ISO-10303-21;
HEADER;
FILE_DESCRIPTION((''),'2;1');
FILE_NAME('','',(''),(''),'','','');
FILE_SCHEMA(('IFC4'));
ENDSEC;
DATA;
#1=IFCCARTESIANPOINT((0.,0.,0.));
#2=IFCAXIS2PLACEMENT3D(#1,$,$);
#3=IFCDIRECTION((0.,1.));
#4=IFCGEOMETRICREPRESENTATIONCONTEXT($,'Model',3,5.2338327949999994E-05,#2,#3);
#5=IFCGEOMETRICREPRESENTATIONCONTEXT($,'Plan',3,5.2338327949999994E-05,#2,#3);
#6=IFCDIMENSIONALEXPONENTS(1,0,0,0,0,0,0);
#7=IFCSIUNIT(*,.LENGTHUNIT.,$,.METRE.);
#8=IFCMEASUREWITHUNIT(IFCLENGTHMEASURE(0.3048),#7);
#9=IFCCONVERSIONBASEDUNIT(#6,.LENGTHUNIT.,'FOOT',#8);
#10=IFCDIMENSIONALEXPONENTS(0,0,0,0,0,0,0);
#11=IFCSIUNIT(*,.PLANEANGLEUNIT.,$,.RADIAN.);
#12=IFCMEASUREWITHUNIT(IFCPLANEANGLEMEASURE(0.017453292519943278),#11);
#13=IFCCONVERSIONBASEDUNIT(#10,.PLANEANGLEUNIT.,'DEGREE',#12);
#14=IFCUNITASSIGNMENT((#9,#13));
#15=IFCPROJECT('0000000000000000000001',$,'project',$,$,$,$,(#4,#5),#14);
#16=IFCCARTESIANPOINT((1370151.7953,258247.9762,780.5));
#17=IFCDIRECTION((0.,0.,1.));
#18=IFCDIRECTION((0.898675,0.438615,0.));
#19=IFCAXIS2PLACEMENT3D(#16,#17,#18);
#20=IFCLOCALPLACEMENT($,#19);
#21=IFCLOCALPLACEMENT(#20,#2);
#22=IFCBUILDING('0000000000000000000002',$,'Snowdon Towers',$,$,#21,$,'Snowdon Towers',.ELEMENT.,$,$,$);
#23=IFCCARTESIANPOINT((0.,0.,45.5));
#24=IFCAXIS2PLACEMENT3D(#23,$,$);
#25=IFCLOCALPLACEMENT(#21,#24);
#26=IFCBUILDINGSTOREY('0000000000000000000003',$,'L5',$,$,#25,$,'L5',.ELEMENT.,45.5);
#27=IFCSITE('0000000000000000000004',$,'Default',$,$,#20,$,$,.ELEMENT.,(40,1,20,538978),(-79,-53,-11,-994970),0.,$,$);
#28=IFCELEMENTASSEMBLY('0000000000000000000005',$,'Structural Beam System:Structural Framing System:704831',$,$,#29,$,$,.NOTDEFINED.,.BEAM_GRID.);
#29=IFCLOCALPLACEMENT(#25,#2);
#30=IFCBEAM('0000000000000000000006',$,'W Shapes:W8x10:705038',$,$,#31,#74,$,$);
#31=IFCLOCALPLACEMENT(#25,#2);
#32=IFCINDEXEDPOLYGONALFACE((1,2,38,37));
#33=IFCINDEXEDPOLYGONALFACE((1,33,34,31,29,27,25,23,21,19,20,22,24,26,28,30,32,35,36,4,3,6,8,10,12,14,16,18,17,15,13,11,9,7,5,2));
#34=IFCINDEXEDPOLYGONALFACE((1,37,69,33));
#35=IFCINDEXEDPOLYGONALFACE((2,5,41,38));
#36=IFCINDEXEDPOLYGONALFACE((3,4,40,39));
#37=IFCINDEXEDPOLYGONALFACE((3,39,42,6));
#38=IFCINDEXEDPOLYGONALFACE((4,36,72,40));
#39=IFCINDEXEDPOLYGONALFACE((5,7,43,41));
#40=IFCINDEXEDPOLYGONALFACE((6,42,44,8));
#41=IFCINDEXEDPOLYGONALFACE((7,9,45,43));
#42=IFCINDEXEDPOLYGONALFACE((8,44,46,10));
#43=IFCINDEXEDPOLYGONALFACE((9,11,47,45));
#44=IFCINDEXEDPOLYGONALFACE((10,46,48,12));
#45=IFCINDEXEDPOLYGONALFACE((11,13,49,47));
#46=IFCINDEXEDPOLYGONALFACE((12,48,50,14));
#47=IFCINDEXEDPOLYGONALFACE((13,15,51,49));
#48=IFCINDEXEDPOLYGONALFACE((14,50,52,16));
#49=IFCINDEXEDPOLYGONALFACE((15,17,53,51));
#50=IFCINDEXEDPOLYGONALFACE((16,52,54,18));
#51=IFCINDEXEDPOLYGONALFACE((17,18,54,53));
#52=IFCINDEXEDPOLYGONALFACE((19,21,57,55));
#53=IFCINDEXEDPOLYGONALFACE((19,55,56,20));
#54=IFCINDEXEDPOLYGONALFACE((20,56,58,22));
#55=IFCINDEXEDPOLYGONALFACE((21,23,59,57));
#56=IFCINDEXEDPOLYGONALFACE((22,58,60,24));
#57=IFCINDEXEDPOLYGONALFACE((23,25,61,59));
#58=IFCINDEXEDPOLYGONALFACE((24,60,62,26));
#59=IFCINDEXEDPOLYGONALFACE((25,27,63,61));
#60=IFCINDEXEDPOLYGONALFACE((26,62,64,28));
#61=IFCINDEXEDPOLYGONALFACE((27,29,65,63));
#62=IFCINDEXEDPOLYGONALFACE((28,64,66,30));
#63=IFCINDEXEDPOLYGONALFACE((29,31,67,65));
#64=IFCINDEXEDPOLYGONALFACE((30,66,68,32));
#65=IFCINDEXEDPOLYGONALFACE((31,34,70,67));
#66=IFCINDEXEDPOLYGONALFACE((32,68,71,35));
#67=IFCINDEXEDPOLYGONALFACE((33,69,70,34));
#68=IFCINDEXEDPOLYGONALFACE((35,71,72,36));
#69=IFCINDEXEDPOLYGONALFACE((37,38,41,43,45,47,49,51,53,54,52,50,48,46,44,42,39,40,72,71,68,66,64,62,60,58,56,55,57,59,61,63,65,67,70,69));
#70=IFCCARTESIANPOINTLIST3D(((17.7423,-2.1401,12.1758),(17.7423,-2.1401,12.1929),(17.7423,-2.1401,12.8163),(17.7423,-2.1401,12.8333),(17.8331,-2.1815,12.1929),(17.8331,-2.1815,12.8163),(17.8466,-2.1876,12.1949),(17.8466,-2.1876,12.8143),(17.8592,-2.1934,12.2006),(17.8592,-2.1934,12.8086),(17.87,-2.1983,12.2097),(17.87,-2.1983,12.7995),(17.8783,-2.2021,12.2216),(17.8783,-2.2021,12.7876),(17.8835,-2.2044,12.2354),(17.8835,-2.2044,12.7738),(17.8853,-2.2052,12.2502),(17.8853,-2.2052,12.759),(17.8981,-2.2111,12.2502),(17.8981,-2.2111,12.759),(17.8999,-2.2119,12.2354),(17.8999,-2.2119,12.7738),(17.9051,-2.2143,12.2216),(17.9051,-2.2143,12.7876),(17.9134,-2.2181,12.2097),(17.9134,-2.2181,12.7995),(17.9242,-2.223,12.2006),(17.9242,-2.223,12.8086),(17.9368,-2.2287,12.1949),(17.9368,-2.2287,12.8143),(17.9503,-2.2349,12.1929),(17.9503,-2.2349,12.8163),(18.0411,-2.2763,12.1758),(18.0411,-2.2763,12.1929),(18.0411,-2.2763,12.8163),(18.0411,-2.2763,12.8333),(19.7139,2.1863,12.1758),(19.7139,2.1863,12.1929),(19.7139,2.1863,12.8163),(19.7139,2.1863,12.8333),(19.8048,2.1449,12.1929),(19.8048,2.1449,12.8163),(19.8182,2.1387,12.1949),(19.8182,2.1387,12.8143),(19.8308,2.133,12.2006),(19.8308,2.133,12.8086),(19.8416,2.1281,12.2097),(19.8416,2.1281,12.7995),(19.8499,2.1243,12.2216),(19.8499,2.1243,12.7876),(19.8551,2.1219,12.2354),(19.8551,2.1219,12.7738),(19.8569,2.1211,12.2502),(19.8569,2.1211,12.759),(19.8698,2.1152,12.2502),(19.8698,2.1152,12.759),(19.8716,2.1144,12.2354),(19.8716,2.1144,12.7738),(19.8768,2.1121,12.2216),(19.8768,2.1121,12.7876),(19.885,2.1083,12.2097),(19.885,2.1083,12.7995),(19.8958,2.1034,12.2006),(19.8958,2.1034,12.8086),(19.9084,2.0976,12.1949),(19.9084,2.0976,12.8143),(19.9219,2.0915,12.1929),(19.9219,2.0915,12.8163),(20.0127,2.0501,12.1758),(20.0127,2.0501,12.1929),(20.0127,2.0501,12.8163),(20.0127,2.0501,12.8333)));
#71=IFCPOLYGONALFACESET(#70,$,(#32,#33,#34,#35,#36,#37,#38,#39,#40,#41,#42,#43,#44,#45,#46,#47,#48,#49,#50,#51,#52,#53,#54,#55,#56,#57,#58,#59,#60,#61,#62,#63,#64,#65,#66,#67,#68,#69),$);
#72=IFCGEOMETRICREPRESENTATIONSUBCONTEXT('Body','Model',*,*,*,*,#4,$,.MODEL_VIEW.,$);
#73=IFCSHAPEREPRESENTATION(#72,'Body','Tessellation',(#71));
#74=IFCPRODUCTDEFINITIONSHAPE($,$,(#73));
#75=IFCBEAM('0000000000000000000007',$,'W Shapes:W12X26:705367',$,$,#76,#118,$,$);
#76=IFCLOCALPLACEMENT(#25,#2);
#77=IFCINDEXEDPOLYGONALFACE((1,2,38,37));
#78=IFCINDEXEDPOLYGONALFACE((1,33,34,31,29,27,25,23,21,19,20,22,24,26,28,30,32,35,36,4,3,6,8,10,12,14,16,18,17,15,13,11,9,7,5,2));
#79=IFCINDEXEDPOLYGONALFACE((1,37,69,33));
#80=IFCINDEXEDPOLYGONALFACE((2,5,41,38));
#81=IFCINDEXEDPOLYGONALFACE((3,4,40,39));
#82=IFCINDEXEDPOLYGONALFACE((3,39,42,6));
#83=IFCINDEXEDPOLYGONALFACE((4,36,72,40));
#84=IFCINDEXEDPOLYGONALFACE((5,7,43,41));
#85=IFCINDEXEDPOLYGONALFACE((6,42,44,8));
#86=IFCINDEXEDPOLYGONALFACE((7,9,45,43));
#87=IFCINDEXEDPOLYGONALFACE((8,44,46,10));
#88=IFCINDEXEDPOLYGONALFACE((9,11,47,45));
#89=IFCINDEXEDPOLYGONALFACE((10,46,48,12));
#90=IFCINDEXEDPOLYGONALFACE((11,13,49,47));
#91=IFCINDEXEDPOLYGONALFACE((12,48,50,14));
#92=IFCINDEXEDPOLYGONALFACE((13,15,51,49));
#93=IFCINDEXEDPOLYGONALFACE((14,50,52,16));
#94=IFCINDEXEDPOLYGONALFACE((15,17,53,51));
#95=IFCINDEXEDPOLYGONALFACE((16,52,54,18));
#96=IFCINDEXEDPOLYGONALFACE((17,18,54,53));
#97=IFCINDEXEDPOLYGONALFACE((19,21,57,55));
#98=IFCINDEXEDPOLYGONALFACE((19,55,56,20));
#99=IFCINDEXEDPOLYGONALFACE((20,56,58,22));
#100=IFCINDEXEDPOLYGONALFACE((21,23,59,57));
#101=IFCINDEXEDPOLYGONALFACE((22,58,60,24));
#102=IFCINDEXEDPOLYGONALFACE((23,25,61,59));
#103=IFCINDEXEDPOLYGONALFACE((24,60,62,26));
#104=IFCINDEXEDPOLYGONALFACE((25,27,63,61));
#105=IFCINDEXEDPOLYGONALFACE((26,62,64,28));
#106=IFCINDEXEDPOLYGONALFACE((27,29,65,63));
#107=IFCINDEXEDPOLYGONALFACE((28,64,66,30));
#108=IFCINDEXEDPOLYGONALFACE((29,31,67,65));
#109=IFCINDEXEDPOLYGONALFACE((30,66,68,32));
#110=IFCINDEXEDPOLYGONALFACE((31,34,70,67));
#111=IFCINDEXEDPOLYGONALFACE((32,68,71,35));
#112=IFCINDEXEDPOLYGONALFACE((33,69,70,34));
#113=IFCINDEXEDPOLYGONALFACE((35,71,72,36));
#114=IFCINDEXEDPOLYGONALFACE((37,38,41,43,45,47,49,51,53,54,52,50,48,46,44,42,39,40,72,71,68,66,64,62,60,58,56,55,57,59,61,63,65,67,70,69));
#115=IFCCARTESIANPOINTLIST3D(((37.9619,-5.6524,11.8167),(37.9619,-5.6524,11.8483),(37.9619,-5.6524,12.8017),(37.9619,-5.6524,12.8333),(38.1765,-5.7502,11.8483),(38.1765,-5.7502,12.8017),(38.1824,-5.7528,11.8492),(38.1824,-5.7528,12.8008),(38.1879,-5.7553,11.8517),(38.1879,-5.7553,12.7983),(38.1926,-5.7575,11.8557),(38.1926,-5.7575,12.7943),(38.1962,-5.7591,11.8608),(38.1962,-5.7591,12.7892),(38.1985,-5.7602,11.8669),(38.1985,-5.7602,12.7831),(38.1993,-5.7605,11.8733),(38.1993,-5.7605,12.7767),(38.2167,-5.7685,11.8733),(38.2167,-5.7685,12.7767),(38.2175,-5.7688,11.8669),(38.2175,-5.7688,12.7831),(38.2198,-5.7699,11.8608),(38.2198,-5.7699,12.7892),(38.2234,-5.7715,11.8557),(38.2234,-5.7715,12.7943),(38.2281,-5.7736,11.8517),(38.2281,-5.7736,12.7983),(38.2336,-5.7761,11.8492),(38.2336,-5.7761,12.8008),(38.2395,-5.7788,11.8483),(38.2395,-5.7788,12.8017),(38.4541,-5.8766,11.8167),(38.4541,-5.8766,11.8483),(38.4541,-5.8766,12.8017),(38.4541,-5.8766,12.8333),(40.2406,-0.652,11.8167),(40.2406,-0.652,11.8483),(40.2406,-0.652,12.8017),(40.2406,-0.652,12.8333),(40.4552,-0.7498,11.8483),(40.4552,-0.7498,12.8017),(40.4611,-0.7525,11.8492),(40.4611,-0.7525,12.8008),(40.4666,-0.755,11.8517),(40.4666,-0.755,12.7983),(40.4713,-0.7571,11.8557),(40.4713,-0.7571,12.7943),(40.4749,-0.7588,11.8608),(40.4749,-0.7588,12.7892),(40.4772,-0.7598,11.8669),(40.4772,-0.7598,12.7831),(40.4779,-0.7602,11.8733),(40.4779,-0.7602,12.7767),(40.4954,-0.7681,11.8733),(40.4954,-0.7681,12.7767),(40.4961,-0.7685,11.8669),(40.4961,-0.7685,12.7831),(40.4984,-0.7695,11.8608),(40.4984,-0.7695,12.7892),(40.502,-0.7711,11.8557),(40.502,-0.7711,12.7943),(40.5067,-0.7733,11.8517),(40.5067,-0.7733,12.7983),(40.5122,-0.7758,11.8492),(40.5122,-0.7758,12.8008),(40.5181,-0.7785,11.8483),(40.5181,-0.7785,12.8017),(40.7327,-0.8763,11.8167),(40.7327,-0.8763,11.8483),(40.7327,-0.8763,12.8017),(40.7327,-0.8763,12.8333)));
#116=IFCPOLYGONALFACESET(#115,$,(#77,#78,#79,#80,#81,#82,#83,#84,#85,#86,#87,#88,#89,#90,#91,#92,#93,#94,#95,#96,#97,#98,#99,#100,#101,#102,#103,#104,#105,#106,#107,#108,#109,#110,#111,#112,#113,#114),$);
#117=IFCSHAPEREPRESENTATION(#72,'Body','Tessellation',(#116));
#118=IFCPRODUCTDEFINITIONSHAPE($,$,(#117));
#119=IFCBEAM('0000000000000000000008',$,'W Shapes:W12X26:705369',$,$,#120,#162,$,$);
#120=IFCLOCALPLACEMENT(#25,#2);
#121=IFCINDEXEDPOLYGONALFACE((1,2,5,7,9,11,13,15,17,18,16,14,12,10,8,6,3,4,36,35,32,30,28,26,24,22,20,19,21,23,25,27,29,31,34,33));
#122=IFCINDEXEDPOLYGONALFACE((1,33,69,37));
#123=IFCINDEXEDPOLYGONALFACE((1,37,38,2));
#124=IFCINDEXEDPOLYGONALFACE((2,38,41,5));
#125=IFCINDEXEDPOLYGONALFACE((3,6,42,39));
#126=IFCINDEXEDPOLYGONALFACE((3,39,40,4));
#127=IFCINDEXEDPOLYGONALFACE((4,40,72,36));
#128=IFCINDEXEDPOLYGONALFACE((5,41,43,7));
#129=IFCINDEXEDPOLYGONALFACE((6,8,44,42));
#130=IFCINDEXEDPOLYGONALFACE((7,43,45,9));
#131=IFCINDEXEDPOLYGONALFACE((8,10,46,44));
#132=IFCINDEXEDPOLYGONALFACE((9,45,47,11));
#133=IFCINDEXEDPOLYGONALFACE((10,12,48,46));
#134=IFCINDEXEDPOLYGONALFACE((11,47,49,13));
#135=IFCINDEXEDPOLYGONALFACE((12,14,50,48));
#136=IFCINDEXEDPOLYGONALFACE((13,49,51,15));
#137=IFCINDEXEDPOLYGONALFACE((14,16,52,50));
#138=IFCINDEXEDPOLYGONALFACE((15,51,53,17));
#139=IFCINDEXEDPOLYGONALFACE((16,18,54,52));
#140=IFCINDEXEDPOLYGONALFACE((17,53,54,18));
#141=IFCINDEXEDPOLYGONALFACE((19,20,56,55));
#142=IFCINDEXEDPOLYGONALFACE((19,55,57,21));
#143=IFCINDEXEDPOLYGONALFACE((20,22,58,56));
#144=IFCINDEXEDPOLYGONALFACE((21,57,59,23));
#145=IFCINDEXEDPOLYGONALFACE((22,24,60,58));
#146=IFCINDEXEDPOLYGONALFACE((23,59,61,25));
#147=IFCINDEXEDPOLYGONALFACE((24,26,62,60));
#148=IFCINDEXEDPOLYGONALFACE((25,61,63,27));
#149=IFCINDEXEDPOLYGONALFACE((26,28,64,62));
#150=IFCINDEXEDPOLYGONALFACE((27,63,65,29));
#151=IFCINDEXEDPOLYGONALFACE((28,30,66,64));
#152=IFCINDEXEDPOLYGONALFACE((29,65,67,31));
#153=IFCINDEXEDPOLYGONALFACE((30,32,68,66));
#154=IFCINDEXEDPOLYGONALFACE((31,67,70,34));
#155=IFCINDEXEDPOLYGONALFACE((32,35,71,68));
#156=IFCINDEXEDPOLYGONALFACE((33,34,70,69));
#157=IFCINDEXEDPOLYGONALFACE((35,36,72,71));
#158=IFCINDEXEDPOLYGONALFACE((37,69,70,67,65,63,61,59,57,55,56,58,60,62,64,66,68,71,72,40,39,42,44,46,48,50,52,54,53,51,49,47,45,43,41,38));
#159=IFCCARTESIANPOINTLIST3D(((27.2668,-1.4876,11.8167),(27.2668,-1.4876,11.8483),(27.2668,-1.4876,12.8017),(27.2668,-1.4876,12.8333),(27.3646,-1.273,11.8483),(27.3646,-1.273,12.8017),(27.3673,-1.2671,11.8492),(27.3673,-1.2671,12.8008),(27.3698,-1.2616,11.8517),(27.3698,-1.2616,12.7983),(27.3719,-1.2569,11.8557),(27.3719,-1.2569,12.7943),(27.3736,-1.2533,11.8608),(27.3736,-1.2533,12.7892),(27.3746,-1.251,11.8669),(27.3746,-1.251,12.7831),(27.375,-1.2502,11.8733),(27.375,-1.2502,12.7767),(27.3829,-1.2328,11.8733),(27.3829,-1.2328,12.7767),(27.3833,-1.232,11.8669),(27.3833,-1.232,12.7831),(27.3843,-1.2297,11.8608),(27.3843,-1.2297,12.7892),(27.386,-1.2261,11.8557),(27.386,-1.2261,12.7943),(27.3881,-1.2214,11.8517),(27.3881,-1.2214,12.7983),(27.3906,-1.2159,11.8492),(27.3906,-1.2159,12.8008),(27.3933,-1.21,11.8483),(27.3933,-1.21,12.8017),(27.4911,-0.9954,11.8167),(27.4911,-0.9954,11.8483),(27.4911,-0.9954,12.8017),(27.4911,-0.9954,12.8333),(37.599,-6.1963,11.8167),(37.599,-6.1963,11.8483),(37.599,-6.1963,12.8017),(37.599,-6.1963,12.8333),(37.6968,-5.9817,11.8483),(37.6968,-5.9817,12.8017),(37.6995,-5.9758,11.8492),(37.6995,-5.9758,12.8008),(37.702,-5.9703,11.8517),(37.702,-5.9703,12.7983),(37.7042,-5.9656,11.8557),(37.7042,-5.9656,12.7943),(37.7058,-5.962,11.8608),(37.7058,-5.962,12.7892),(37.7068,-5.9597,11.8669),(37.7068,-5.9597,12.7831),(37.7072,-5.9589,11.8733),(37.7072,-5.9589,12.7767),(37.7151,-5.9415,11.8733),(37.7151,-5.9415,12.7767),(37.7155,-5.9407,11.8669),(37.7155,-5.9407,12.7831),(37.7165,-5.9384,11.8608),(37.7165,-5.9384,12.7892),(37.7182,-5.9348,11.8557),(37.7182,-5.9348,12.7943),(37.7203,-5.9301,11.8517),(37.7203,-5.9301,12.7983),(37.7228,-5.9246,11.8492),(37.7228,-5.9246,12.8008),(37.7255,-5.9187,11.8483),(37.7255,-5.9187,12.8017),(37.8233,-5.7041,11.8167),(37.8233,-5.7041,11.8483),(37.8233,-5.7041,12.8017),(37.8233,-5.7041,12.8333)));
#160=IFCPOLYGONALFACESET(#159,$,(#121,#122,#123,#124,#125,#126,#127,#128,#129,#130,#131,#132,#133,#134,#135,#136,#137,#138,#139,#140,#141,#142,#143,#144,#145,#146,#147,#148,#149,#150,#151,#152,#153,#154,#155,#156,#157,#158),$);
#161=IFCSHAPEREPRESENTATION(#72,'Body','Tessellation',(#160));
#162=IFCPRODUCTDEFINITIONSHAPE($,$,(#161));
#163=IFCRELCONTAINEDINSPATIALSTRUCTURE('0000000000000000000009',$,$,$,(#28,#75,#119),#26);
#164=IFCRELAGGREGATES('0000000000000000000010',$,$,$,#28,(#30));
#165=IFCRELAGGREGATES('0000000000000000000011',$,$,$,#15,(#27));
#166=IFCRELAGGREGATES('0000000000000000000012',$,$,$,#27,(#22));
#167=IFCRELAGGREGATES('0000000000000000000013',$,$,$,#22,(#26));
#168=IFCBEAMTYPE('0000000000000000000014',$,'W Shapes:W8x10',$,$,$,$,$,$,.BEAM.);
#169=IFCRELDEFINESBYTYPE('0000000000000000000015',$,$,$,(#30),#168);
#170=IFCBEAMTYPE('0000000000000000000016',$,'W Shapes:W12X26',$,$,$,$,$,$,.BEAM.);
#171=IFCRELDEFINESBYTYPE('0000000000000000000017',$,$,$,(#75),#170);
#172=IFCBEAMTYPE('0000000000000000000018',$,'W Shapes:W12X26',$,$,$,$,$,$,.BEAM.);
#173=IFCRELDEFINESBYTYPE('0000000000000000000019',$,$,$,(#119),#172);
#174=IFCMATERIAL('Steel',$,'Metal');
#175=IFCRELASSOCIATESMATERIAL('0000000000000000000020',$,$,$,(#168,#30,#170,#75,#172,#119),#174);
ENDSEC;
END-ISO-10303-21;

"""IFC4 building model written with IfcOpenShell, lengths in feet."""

from ifc_helpers import new_model, entity, si_unit, converted_unit, direction, frame, origin, place, context, subcontext, project, spatial, line, arc, indexed_curve, outline, extrude, source, transform, mapped, material, type_object, type_shapes, element, aggregate, save


model = new_model("IFC4")

# Units and contexts
model_context = context("Model", 3, precision=5.2338327949999994e-05, world=origin(), true_north=direction((0.0, 1.0)))
plan_context = context("Plan", 3, precision=5.2338327949999994e-05, world=origin(), true_north=direction((0.0, 1.0)))
body_context = subcontext(model_context, "Body", "Model", "MODEL_VIEW")
ifc_project = project(units=[converted_unit("LENGTHUNIT", "FOOT", entity("IfcLengthMeasure", 0.3048), si_unit("LENGTHUNIT", "METRE"), dimensions=[1, 0, 0, 0, 0, 0, 0]), converted_unit("PLANEANGLEUNIT", "DEGREE", entity("IfcPlaneAngleMeasure", 0.017453292519943278), si_unit("PLANEANGLEUNIT", "RADIAN"), dimensions=[0, 0, 0, 0, 0, 0, 0])], contexts=[model_context, plan_context])

# Site, building, storey
site_placement = place(None, frame((1370151.7953, 258247.9762, 780.5), z_axis=(0.0, 0.0, 1.0), x_axis=(0.898675, 0.438615, 0.0)))
site = spatial("IfcSite", under=ifc_project, at=site_placement, Name="Default", CompositionType="ELEMENT", RefLatitude=(40, 1, 20, 538978), RefLongitude=(-79, -53, -11, -994970), RefElevation=0.0)
building_placement = place(site_placement, origin())
building = spatial("IfcBuilding", under=site, at=building_placement, Name="Snowdon Towers", LongName="Snowdon Towers", CompositionType="ELEMENT")
storey_placement = place(building_placement, frame((0.0, 0.0, 45.5)))
storey = spatial("IfcBuildingStorey", under=building, at=storey_placement, Name="L5", LongName="L5", CompositionType="ELEMENT", Elevation=45.5)

# Shared definitions
ifc_material = material(Name="Steel", Category="Metal")

# Element assembly, beam
assembly_1_placement = place(storey_placement, origin())
assembly_1 = element("IfcElementAssembly", 1, at=assembly_1_placement, inside=storey, Name="Structural Beam System:Structural Framing System:704831", AssemblyPlace="NOTDEFINED", PredefinedType="BEAM_GRID")
beam_type_1 = type_object("IfcBeamType", Name="W Shapes:W8x10", PredefinedType="BEAM", material=ifc_material)
shared_shape_1 = source(origin(), body_context, "Body", "SweptSolid", [
    extrude(outline(indexed_curve([(-0.3287, -0.1642), (-0.3117, -0.1642), (-0.3117, -0.0644), (-0.2949, -0.0239), (-0.2544, -0.0071), (0.2544, -0.0071), (0.2949, -0.0239), (0.3117, -0.0644), (0.3117, -0.1642), (0.3288, -0.1642), (0.3288, 0.1642), (0.3117, 0.1642), (0.3117, 0.0644), (0.2949, 0.0239), (0.2544, 0.0071), (-0.2544, 0.0071), (-0.2949, 0.0239), (-0.3117, 0.0644), (-0.3117, 0.1642), (-0.3287, 0.1642)], segments=[line(1, 2, 3), arc(3, 4, 5), line(5, 6), arc(6, 7, 8), line(8, 9, 10, 11, 12, 13), arc(13, 14, 15), line(15, 16), arc(16, 17, 18), line(18, 19, 20, 1)], self_intersect=False)), frame((-2.4518, 0.0, 0.0), z_axis=(1.0, 0.0, 0.0), x_axis=(0.0, 0.0, -1.0)), (0.0, 0.0, 1.0), 4.7544),
])
type_shapes(beam_type_1, [shared_shape_1])
beam_1_placement = place(assembly_1_placement, frame((18.9084, 0.0229, 12.5046), z_axis=(0.0, 0.0, 1.0), x_axis=(0.414693, 0.909961, 0.0)))
beam_1 = element("IfcBeam", 2, at=beam_1_placement, type_object=beam_type_1, material=ifc_material, Name="W Shapes:W8x10:705038", context=body_context, shape_type="MappedRepresentation", body=[
    mapped(shared_shape_1, transform((0.0, 0.0, 0.0), scale=1.0)),
])
aggregate(assembly_1, [beam_1])

# Beams
beam_type_2 = type_object("IfcBeamType", Name="W Shapes:W12X26", PredefinedType="BEAM", material=ifc_material)
shared_shape_2 = source(origin(), body_context, "Body", "SweptSolid", [
    extrude(outline(indexed_curve([(-0.5083, -0.2704), (-0.4767, -0.2704), (-0.4767, -0.0346), (-0.4693, -0.0169), (-0.4517, -0.0096), (0.4517, -0.0096), (0.4693, -0.0169), (0.4767, -0.0346), (0.4767, -0.2704), (0.5083, -0.2704), (0.5083, 0.2704), (0.4767, 0.2704), (0.4767, 0.0346), (0.4693, 0.0169), (0.4517, 0.0096), (-0.4517, 0.0096), (-0.4693, 0.0169), (-0.4767, 0.0346), (-0.4767, 0.2704), (-0.5083, 0.2704)], segments=[line(1, 2, 3), arc(3, 4, 5), line(5, 6), arc(6, 7, 8), line(8, 9, 10, 11, 12, 13), arc(13, 14, 15), line(15, 16), arc(16, 17, 18), line(18, 19, 20, 1)], self_intersect=False)), frame((-3.4805, 0.0, 0.0), z_axis=(1.0, 0.0, 0.0), x_axis=(0.0, 0.0, -1.0)), (0.0, 0.0, 1.0), 5.4951),
])
type_shapes(beam_type_2, [shared_shape_2])
beam_2_placement = place(storey_placement, frame((39.6512, -2.5974, 12.325), z_axis=(0.0, 0.0, 1.0), x_axis=(0.414671, 0.909972, 0.0)))
element("IfcBeam", 3, at=beam_2_placement, inside=storey, type_object=beam_type_2, material=ifc_material, Name="W Shapes:W12X26:705367", context=body_context, shape_type="MappedRepresentation", body=[
    mapped(shared_shape_2, transform((0.0, 0.0, 0.0), scale=1.0)),
])
beam_type_3 = type_object("IfcBeamType", Name="W Shapes:W12X26", PredefinedType="BEAM", material=ifc_material)
shared_shape_3 = source(origin(), body_context, "Body", "SweptSolid", [
    extrude(outline(indexed_curve([(-0.5083, -0.2704), (-0.4767, -0.2704), (-0.4767, -0.0346), (-0.4693, -0.0169), (-0.4517, -0.0096), (0.4517, -0.0096), (0.4693, -0.0169), (0.4767, -0.0346), (0.4767, -0.2704), (0.5083, -0.2704), (0.5083, 0.2704), (0.4767, 0.2704), (0.4767, 0.0346), (0.4693, 0.0169), (0.4517, 0.0096), (-0.4517, 0.0096), (-0.4693, 0.0169), (-0.4767, 0.0346), (-0.4767, 0.2704), (-0.5083, 0.2704)], segments=[line(1, 2, 3), arc(3, 4, 5), line(5, 6), arc(6, 7, 8), line(8, 9, 10, 11, 12, 13), arc(13, 14, 15), line(15, 16), arc(16, 17, 18), line(18, 19, 20, 1)], self_intersect=False)), frame((-5.7296, 0.0, 0.0), z_axis=(1.0, 0.0, 0.0), x_axis=(0.0, 0.0, -1.0)), (0.0, 0.0, 1.0), 11.3546),
])
type_shapes(beam_type_3, [shared_shape_3])
beam_3_placement = place(storey_placement, frame((32.5926, -3.6175, 12.325), z_axis=(0.0, 0.0, 1.0), x_axis=(0.909961, -0.414693, 0.0)))
element("IfcBeam", 4, at=beam_3_placement, inside=storey, type_object=beam_type_3, material=ifc_material, Name="W Shapes:W12X26:705369", context=body_context, shape_type="MappedRepresentation", body=[
    mapped(shared_shape_3, transform((0.0, 0.0, 0.0), scale=1.0)),
])

save(model, "model.ifc")
